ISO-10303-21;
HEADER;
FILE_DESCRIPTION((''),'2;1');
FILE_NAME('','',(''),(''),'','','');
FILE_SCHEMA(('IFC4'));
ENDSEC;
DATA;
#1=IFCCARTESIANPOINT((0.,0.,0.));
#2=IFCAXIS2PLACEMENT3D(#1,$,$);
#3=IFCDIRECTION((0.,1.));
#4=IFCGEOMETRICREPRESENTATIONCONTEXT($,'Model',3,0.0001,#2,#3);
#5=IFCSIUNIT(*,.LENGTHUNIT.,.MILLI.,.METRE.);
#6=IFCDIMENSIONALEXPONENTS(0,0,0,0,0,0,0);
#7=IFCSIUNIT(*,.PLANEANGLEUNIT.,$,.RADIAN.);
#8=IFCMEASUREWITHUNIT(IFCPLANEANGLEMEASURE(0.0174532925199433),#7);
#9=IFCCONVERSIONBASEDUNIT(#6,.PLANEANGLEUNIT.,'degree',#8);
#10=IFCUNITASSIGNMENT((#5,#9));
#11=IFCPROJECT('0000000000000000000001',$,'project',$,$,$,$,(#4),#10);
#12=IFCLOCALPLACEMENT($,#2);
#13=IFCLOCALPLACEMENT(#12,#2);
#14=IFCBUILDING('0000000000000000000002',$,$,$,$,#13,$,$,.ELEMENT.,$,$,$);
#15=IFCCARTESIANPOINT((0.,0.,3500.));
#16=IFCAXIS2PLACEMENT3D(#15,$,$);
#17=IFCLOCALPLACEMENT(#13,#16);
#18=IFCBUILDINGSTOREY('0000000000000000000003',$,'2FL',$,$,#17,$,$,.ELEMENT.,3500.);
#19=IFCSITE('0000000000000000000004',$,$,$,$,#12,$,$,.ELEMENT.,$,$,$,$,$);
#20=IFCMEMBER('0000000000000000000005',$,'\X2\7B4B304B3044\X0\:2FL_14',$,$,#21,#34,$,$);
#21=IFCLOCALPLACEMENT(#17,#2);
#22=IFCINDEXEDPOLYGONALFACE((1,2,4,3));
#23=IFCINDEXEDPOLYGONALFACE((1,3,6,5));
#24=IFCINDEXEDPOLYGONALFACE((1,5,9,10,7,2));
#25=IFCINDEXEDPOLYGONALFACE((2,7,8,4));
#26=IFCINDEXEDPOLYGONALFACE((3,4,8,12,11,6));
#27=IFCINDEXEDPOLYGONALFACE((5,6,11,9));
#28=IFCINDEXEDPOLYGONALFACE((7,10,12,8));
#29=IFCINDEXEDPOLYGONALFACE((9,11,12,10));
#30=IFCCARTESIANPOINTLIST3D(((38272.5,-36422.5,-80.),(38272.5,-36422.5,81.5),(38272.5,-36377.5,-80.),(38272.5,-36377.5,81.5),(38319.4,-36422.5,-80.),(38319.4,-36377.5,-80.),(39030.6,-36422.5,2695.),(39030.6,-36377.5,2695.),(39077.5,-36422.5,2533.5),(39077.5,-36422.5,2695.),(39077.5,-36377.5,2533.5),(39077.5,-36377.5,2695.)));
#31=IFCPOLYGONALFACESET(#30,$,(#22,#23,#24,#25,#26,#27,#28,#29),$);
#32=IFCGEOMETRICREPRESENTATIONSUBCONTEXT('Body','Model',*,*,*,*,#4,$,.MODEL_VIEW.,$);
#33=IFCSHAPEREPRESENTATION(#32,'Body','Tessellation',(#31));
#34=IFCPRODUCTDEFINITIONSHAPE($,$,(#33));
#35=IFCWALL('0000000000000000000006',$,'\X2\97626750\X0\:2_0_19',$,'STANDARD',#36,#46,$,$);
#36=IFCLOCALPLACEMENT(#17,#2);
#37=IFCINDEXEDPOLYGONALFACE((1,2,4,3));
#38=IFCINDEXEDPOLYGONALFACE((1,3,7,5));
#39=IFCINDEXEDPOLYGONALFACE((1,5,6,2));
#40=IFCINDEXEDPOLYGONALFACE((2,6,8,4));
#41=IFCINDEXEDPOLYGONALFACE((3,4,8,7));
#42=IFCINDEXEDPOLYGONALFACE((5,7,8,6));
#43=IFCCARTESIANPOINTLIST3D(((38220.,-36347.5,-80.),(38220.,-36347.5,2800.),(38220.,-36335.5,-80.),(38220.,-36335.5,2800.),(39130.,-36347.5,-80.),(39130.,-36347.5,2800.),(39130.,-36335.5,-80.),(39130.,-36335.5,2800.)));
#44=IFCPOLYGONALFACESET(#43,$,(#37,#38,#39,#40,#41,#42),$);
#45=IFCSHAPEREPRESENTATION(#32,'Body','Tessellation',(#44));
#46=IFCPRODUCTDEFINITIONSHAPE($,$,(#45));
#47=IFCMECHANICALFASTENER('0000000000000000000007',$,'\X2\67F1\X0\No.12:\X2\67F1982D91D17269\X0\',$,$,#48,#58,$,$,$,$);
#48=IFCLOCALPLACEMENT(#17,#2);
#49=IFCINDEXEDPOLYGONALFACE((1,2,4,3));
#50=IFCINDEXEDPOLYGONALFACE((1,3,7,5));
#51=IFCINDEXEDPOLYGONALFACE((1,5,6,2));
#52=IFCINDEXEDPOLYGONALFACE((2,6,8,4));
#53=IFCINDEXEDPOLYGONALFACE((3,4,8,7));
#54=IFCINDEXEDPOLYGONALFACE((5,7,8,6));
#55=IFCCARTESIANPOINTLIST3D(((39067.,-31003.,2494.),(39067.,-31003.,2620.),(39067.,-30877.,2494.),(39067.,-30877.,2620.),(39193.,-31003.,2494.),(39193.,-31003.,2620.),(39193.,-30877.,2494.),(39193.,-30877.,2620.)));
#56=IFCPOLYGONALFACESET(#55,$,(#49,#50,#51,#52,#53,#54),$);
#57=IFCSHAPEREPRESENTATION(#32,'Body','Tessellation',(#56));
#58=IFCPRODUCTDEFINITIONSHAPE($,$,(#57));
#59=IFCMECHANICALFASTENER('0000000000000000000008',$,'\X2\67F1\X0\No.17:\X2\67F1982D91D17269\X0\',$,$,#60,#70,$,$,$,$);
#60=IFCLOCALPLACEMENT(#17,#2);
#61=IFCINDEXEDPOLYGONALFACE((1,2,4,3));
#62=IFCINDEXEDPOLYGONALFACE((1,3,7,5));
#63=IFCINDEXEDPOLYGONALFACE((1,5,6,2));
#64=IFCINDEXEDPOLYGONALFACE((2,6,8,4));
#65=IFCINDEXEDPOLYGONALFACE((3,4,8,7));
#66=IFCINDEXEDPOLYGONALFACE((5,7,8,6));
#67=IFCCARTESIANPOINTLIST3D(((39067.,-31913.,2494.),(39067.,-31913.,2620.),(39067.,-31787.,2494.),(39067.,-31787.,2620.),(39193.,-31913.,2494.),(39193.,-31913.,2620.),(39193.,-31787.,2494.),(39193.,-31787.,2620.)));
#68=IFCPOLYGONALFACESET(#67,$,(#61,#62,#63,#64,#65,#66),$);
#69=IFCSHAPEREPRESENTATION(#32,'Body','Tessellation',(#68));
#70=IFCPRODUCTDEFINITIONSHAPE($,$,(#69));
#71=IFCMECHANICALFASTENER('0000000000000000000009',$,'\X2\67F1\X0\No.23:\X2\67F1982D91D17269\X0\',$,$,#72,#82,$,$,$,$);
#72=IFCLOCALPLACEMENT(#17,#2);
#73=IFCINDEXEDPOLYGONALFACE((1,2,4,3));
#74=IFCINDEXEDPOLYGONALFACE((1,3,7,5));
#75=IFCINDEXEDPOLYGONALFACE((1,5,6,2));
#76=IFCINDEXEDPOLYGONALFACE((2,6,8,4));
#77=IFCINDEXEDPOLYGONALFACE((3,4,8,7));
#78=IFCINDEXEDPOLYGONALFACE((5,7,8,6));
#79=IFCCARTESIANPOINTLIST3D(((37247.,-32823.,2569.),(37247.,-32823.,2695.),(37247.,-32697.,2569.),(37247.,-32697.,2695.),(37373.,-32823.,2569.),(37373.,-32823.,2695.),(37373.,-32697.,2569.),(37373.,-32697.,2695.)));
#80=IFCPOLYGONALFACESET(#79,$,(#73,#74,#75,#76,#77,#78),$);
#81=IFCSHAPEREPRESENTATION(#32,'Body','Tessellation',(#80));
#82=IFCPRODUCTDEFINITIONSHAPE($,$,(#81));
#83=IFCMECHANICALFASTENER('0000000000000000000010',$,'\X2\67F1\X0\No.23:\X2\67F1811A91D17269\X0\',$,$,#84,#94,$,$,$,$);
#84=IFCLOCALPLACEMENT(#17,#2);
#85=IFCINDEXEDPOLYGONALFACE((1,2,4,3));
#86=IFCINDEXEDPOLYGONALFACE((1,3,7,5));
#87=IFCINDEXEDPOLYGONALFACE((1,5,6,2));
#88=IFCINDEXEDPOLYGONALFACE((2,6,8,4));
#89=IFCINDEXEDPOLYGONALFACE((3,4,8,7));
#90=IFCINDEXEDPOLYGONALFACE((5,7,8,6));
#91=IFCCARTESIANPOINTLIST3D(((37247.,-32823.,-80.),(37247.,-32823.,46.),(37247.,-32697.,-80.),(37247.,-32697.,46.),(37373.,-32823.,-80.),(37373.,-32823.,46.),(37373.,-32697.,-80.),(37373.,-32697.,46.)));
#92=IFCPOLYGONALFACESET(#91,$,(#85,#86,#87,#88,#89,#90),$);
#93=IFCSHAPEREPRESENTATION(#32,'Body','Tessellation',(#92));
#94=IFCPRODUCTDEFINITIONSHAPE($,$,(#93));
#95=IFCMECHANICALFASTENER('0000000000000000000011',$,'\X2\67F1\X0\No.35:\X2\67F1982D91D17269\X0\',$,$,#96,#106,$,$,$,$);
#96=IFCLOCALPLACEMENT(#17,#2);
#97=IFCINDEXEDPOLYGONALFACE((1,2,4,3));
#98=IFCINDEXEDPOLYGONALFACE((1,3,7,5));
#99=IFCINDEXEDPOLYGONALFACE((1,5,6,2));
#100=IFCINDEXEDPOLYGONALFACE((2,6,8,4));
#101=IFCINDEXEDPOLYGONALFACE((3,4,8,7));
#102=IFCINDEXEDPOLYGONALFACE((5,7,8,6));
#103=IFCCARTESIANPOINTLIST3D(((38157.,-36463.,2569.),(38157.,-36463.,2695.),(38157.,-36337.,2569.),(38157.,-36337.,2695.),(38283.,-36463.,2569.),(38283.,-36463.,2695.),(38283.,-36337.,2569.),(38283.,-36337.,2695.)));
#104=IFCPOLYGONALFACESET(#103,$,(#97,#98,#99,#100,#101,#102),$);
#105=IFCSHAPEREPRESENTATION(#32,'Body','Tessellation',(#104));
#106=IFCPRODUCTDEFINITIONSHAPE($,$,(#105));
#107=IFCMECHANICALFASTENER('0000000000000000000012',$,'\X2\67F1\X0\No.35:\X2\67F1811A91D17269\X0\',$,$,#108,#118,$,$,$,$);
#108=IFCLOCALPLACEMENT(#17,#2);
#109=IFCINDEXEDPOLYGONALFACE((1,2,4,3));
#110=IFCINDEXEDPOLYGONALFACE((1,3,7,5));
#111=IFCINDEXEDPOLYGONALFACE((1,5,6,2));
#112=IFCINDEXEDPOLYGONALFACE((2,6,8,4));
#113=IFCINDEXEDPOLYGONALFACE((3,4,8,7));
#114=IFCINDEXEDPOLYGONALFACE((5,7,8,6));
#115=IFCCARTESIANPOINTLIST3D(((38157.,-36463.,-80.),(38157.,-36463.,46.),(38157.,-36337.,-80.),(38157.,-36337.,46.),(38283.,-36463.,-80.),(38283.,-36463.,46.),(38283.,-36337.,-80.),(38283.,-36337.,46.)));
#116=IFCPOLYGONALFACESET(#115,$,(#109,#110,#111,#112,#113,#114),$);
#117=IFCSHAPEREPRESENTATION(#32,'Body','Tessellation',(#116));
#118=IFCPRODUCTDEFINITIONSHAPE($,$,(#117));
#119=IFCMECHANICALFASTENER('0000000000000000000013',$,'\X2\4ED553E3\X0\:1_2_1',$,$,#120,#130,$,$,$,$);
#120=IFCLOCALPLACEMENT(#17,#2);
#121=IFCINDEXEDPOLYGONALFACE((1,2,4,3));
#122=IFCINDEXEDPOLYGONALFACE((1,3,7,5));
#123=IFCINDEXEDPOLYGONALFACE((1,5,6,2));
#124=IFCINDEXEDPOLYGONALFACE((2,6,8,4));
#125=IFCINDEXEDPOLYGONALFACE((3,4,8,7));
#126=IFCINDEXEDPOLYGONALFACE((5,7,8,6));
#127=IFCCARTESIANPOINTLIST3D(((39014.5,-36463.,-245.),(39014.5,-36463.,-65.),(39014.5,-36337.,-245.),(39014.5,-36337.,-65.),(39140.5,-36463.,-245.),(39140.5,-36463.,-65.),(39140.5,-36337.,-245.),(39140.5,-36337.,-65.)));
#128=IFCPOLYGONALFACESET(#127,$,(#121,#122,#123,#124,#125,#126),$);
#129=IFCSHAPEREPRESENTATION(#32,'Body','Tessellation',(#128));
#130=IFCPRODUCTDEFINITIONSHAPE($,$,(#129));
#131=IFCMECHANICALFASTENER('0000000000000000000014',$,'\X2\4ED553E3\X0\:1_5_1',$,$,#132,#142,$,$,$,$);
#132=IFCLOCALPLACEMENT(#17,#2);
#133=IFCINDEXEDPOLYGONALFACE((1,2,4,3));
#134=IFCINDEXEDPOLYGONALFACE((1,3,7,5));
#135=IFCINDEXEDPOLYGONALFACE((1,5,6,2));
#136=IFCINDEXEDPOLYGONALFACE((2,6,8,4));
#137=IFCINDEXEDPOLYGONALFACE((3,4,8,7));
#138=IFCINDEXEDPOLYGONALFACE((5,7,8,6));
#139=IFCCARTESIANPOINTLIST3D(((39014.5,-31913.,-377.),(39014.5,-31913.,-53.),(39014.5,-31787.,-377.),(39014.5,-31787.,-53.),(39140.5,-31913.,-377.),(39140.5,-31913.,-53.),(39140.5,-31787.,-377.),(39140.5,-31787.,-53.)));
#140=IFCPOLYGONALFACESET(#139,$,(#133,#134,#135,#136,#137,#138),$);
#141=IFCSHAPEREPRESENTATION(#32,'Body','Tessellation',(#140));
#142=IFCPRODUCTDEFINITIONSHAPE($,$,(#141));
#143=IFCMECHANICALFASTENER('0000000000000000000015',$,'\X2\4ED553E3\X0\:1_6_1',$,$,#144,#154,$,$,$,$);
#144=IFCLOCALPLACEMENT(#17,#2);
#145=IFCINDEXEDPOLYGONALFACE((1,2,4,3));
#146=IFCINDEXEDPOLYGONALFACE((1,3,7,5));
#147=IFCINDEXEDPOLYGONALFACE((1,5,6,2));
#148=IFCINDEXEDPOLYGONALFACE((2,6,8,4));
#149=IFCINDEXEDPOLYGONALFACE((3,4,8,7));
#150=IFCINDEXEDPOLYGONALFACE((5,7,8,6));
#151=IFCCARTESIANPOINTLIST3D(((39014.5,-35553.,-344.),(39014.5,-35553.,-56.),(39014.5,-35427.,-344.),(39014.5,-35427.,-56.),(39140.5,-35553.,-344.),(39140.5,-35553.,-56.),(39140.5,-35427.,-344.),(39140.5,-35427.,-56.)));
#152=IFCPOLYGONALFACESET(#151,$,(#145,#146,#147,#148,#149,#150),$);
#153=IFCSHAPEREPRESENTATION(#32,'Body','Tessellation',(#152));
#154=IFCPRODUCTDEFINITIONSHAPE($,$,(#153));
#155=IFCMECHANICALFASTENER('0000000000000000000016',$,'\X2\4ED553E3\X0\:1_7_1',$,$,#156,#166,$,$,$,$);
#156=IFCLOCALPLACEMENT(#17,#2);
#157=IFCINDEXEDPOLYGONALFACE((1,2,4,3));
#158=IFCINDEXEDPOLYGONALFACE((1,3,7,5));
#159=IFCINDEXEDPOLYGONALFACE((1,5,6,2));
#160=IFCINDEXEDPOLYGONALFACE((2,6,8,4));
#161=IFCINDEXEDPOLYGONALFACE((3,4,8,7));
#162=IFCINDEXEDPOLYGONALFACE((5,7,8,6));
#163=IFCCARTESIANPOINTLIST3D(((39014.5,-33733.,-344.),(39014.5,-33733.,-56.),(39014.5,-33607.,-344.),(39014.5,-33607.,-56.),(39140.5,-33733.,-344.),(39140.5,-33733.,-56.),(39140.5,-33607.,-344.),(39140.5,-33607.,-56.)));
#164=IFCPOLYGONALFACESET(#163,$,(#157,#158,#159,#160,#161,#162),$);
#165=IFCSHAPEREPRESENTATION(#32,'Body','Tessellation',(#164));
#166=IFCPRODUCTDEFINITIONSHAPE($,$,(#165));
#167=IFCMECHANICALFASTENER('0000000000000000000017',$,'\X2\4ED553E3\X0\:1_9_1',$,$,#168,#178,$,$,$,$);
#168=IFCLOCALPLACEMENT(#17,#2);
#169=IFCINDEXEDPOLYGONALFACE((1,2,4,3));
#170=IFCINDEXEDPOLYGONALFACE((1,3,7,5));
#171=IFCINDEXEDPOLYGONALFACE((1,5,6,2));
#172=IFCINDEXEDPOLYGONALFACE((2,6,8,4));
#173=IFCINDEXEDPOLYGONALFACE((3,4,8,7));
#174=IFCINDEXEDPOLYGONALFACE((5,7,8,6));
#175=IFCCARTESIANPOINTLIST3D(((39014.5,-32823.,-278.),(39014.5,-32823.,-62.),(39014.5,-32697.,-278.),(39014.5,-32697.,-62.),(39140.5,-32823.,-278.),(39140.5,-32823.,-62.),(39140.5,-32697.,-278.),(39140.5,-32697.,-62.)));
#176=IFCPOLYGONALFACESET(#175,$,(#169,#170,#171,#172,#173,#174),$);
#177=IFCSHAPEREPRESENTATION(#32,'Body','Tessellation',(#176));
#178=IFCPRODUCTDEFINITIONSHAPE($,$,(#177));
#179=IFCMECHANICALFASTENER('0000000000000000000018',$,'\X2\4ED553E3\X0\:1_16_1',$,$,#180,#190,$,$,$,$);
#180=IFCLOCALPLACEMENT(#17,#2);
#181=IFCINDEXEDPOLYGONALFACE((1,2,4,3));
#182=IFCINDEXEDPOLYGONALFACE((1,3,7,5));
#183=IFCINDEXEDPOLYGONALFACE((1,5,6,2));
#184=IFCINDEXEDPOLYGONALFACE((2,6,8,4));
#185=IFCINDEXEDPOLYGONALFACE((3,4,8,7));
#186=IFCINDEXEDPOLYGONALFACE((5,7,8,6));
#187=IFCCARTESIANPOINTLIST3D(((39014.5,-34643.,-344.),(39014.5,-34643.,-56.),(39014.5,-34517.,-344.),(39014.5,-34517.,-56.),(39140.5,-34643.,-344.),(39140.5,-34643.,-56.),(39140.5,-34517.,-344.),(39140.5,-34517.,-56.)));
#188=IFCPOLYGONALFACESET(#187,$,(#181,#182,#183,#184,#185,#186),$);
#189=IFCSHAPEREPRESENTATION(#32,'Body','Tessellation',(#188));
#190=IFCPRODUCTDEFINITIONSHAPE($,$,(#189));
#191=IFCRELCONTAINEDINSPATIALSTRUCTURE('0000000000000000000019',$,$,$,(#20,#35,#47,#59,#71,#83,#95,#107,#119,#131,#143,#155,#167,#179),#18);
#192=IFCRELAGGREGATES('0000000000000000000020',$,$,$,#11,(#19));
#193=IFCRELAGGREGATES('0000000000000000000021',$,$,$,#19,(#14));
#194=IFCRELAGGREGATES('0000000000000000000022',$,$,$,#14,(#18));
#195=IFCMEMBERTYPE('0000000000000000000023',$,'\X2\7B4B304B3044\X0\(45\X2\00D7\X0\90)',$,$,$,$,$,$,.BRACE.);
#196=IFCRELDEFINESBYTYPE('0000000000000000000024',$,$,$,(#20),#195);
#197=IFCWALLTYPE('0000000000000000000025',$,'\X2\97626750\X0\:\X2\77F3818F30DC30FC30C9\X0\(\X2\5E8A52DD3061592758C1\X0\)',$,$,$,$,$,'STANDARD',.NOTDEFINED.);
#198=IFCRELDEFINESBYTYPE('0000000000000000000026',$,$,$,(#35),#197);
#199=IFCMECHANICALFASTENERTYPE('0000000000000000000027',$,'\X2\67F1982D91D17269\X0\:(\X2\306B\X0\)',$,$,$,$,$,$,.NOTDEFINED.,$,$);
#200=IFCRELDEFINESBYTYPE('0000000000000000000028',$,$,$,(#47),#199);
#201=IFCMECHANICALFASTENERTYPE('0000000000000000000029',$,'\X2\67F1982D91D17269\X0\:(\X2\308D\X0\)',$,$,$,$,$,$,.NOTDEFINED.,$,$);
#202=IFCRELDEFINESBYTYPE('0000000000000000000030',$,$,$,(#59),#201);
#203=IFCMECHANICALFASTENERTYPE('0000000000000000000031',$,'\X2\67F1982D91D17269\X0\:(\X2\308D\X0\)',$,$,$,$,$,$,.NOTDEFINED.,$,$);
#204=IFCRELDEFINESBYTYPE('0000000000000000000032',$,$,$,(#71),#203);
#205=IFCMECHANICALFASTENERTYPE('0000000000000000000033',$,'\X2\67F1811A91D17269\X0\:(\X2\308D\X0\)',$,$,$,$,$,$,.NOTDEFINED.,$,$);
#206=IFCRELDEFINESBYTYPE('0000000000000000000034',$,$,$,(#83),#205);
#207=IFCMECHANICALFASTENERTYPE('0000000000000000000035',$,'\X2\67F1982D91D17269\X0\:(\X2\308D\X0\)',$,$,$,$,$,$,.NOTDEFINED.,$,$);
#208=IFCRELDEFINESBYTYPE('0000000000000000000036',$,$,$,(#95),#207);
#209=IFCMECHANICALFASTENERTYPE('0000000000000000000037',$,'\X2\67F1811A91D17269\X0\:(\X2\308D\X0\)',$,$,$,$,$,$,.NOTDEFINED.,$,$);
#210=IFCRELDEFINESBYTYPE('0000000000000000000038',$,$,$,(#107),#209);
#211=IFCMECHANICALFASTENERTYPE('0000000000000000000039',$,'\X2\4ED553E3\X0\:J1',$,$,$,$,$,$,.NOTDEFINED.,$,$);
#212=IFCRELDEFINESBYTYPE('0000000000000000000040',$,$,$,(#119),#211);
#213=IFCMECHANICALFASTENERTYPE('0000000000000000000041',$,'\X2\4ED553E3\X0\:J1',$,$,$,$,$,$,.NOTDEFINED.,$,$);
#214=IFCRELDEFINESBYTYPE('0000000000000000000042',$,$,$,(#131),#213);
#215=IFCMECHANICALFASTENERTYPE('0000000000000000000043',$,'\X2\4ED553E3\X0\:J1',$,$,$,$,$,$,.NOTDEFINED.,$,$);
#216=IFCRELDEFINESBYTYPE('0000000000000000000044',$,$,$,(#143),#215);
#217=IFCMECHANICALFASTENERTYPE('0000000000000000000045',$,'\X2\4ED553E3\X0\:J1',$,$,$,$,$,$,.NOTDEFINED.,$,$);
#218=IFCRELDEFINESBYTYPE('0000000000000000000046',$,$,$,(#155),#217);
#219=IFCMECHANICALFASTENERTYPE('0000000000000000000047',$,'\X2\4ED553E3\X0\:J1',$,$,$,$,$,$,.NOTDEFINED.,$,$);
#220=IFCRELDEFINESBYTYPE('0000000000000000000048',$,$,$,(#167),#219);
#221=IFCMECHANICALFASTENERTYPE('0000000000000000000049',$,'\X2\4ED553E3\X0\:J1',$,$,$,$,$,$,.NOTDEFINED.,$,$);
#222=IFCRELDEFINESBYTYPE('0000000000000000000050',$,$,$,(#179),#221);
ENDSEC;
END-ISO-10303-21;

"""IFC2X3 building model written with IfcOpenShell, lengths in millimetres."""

from ifc_helpers import new_model, entity, si_unit, converted_unit, direction, frame, origin, origin_with_axes, origin_2d, place, context, subcontext, project, spatial, polyline, rectangle, outline, extrude, type_object, element, save


model = new_model("IFC2X3")

# Units and contexts
model_context = context("Model", 3, precision=0.0001, world=origin(), true_north=direction((0.0, 1.0)))
body_context = subcontext(model_context, "Body", "Model", "MODEL_VIEW")
ifc_project = project(units=[si_unit("LENGTHUNIT", "METRE", prefix="MILLI"), converted_unit("PLANEANGLEUNIT", "degree", entity("IfcPlaneAngleMeasure", 0.0174532925199433), si_unit("PLANEANGLEUNIT", "RADIAN"), dimensions=[0, 0, 0, 0, 0, 0, 0])], contexts=[model_context])

# Site, building, storey
site_placement = place(None, origin())
site = spatial("IfcSite", under=ifc_project, at=site_placement, CompositionType="ELEMENT")
building_placement = place(site_placement, origin())
building = spatial("IfcBuilding", under=site, at=building_placement, CompositionType="ELEMENT")
storey_placement = place(building_placement, frame((0.0, 0.0, 3500.0)))
storey = spatial("IfcBuildingStorey", under=building, at=storey_placement, Name="2FL", CompositionType="ELEMENT", Elevation=3500.0)

# Member
member_type_1 = type_object("IfcMemberType", Name="筋かい(45×90)", PredefinedType="BRACE")
member_1_placement = place(storey_placement, frame((38272.5, -36400.0, -80.0), z_axis=(0.278604, 0.0, 0.960406), x_axis=(-0.960406, 0.0, 0.278604)))
element("IfcMember", 1, at=member_1_placement, inside=storey, type_object=member_type_1, Name="筋かい:2FL_14", context=body_context, shape_type="SweptSolid", body=[
    extrude(outline(polyline([(0.0, 0.0), (13.1, -45.0), (2734.3, -45.0), (2889.4, 0.0), (2876.3, 45.0), (155.1, 45.0), (0.0, 0.0)])), frame((0.0, -22.5, 0.0), z_axis=(0.0, 1.0, 0.0), x_axis=(0.0, 0.0, 1.0)), (0.0, 0.0, 1.0), 45.0),
])

# Wall
wall_type = type_object("IfcWallType", Name="面材:石膏ボード(床勝ち大壁)", ElementType="STANDARD", PredefinedType="NOTDEFINED")
wall_placement = place(storey_placement, frame((38675.0, -36335.5, -80.0), z_axis=(0.0, -1.0, 0.0), x_axis=(1.0, 0.0, 0.0)))
element("IfcWall", 2, at=wall_placement, inside=storey, type_object=wall_type, Name="面材:2_0_19", ObjectType="STANDARD", context=body_context, shape_type="SweptSolid", body=[
    extrude(outline(polyline([(455.0, 0.0, 0.0), (-455.0, 0.0, 0.0), (-455.0, 2880.0, 0.0), (455.0, 2880.0, 0.0), (455.0, 0.0, 0.0)])), origin_with_axes(), (0.0, 0.0, 1.0), 12.0),
])

# Mechanical fasteners
mechanical_fastener_type_1 = type_object("IfcMechanicalFastenerType", Name="柱頭金物:(に)")
mechanical_fastener_1_placement = place(storey_placement, frame((39130.0, -30940.0, 2494.0)))
element("IfcMechanicalFastener", 3, at=mechanical_fastener_1_placement, inside=storey, type_object=mechanical_fastener_type_1, Name="柱No.12:柱頭金物", context=body_context, shape_type="SweptSolid", body=[
    extrude(rectangle(XDim=126.0, YDim=126.0, at=origin_2d()), origin_with_axes(), (0.0, 0.0, 1.0), 126.0),
])
mechanical_fastener_type_2 = type_object("IfcMechanicalFastenerType", Name="柱頭金物:(ろ)")
mechanical_fastener_2_placement = place(storey_placement, frame((39130.0, -31850.0, 2494.0)))
element("IfcMechanicalFastener", 4, at=mechanical_fastener_2_placement, inside=storey, type_object=mechanical_fastener_type_2, Name="柱No.17:柱頭金物", context=body_context, shape_type="SweptSolid", body=[
    extrude(rectangle(XDim=126.0, YDim=126.0, at=origin_2d()), origin_with_axes(), (0.0, 0.0, 1.0), 126.0),
])
mechanical_fastener_type_3 = type_object("IfcMechanicalFastenerType", Name="柱頭金物:(ろ)")
mechanical_fastener_3_placement = place(storey_placement, frame((37310.0, -32760.0, 2569.0)))
element("IfcMechanicalFastener", 5, at=mechanical_fastener_3_placement, inside=storey, type_object=mechanical_fastener_type_3, Name="柱No.23:柱頭金物", context=body_context, shape_type="SweptSolid", body=[
    extrude(rectangle(XDim=126.0, YDim=126.0, at=origin_2d()), origin_with_axes(), (0.0, 0.0, 1.0), 126.0),
])
mechanical_fastener_type_4 = type_object("IfcMechanicalFastenerType", Name="柱脚金物:(ろ)")
mechanical_fastener_4_placement = place(storey_placement, frame((37310.0, -32760.0, -80.0)))
element("IfcMechanicalFastener", 6, at=mechanical_fastener_4_placement, inside=storey, type_object=mechanical_fastener_type_4, Name="柱No.23:柱脚金物", context=body_context, shape_type="SweptSolid", body=[
    extrude(rectangle(XDim=126.0, YDim=126.0, at=origin_2d()), origin_with_axes(), (0.0, 0.0, 1.0), 126.0),
])
mechanical_fastener_type_5 = type_object("IfcMechanicalFastenerType", Name="柱頭金物:(ろ)")
mechanical_fastener_5_placement = place(storey_placement, frame((38220.0, -36400.0, 2569.0)))
element("IfcMechanicalFastener", 7, at=mechanical_fastener_5_placement, inside=storey, type_object=mechanical_fastener_type_5, Name="柱No.35:柱頭金物", context=body_context, shape_type="SweptSolid", body=[
    extrude(rectangle(XDim=126.0, YDim=126.0, at=origin_2d()), origin_with_axes(), (0.0, 0.0, 1.0), 126.0),
])
mechanical_fastener_type_6 = type_object("IfcMechanicalFastenerType", Name="柱脚金物:(ろ)")
mechanical_fastener_6_placement = place(storey_placement, frame((38220.0, -36400.0, -80.0)))
element("IfcMechanicalFastener", 8, at=mechanical_fastener_6_placement, inside=storey, type_object=mechanical_fastener_type_6, Name="柱No.35:柱脚金物", context=body_context, shape_type="SweptSolid", body=[
    extrude(rectangle(XDim=126.0, YDim=126.0, at=origin_2d()), origin_with_axes(), (0.0, 0.0, 1.0), 126.0),
])
mechanical_fastener_type_7 = type_object("IfcMechanicalFastenerType", Name="仕口:J1")
mechanical_fastener_7_placement = place(storey_placement, frame((39077.5, -36400.0, -245.0)))
element("IfcMechanicalFastener", 9, at=mechanical_fastener_7_placement, inside=storey, type_object=mechanical_fastener_type_7, Name="仕口:1_2_1", context=body_context, shape_type="SweptSolid", body=[
    extrude(rectangle(XDim=126.0, YDim=126.0, at=origin_2d()), origin_with_axes(), (0.0, 0.0, 1.0), 180.0),
])
mechanical_fastener_type_8 = type_object("IfcMechanicalFastenerType", Name="仕口:J1")
mechanical_fastener_8_placement = place(storey_placement, frame((39077.5, -31850.0, -377.0)))
element("IfcMechanicalFastener", 10, at=mechanical_fastener_8_placement, inside=storey, type_object=mechanical_fastener_type_8, Name="仕口:1_5_1", context=body_context, shape_type="SweptSolid", body=[
    extrude(rectangle(XDim=126.0, YDim=126.0, at=origin_2d()), origin_with_axes(), (0.0, 0.0, 1.0), 324.0),
])
mechanical_fastener_type_9 = type_object("IfcMechanicalFastenerType", Name="仕口:J1")
mechanical_fastener_9_placement = place(storey_placement, frame((39077.5, -35490.0, -344.0)))
element("IfcMechanicalFastener", 11, at=mechanical_fastener_9_placement, inside=storey, type_object=mechanical_fastener_type_9, Name="仕口:1_6_1", context=body_context, shape_type="SweptSolid", body=[
    extrude(rectangle(XDim=126.0, YDim=126.0, at=origin_2d()), origin_with_axes(), (0.0, 0.0, 1.0), 288.0),
])
mechanical_fastener_type_10 = type_object("IfcMechanicalFastenerType", Name="仕口:J1")
mechanical_fastener_10_placement = place(storey_placement, frame((39077.5, -33670.0, -344.0)))
element("IfcMechanicalFastener", 12, at=mechanical_fastener_10_placement, inside=storey, type_object=mechanical_fastener_type_10, Name="仕口:1_7_1", context=body_context, shape_type="SweptSolid", body=[
    extrude(rectangle(XDim=126.0, YDim=126.0, at=origin_2d()), origin_with_axes(), (0.0, 0.0, 1.0), 288.0),
])
mechanical_fastener_type_11 = type_object("IfcMechanicalFastenerType", Name="仕口:J1")
mechanical_fastener_11_placement = place(storey_placement, frame((39077.5, -32760.0, -278.0)))
element("IfcMechanicalFastener", 13, at=mechanical_fastener_11_placement, inside=storey, type_object=mechanical_fastener_type_11, Name="仕口:1_9_1", context=body_context, shape_type="SweptSolid", body=[
    extrude(rectangle(XDim=126.0, YDim=126.0, at=origin_2d()), origin_with_axes(), (0.0, 0.0, 1.0), 216.0),
])
mechanical_fastener_type_12 = type_object("IfcMechanicalFastenerType", Name="仕口:J1")
mechanical_fastener_12_placement = place(storey_placement, frame((39077.5, -34580.0, -344.0)))
element("IfcMechanicalFastener", 14, at=mechanical_fastener_12_placement, inside=storey, type_object=mechanical_fastener_type_12, Name="仕口:1_16_1", context=body_context, shape_type="SweptSolid", body=[
    extrude(rectangle(XDim=126.0, YDim=126.0, at=origin_2d()), origin_with_axes(), (0.0, 0.0, 1.0), 288.0),
])

save(model, "model.ifc")
